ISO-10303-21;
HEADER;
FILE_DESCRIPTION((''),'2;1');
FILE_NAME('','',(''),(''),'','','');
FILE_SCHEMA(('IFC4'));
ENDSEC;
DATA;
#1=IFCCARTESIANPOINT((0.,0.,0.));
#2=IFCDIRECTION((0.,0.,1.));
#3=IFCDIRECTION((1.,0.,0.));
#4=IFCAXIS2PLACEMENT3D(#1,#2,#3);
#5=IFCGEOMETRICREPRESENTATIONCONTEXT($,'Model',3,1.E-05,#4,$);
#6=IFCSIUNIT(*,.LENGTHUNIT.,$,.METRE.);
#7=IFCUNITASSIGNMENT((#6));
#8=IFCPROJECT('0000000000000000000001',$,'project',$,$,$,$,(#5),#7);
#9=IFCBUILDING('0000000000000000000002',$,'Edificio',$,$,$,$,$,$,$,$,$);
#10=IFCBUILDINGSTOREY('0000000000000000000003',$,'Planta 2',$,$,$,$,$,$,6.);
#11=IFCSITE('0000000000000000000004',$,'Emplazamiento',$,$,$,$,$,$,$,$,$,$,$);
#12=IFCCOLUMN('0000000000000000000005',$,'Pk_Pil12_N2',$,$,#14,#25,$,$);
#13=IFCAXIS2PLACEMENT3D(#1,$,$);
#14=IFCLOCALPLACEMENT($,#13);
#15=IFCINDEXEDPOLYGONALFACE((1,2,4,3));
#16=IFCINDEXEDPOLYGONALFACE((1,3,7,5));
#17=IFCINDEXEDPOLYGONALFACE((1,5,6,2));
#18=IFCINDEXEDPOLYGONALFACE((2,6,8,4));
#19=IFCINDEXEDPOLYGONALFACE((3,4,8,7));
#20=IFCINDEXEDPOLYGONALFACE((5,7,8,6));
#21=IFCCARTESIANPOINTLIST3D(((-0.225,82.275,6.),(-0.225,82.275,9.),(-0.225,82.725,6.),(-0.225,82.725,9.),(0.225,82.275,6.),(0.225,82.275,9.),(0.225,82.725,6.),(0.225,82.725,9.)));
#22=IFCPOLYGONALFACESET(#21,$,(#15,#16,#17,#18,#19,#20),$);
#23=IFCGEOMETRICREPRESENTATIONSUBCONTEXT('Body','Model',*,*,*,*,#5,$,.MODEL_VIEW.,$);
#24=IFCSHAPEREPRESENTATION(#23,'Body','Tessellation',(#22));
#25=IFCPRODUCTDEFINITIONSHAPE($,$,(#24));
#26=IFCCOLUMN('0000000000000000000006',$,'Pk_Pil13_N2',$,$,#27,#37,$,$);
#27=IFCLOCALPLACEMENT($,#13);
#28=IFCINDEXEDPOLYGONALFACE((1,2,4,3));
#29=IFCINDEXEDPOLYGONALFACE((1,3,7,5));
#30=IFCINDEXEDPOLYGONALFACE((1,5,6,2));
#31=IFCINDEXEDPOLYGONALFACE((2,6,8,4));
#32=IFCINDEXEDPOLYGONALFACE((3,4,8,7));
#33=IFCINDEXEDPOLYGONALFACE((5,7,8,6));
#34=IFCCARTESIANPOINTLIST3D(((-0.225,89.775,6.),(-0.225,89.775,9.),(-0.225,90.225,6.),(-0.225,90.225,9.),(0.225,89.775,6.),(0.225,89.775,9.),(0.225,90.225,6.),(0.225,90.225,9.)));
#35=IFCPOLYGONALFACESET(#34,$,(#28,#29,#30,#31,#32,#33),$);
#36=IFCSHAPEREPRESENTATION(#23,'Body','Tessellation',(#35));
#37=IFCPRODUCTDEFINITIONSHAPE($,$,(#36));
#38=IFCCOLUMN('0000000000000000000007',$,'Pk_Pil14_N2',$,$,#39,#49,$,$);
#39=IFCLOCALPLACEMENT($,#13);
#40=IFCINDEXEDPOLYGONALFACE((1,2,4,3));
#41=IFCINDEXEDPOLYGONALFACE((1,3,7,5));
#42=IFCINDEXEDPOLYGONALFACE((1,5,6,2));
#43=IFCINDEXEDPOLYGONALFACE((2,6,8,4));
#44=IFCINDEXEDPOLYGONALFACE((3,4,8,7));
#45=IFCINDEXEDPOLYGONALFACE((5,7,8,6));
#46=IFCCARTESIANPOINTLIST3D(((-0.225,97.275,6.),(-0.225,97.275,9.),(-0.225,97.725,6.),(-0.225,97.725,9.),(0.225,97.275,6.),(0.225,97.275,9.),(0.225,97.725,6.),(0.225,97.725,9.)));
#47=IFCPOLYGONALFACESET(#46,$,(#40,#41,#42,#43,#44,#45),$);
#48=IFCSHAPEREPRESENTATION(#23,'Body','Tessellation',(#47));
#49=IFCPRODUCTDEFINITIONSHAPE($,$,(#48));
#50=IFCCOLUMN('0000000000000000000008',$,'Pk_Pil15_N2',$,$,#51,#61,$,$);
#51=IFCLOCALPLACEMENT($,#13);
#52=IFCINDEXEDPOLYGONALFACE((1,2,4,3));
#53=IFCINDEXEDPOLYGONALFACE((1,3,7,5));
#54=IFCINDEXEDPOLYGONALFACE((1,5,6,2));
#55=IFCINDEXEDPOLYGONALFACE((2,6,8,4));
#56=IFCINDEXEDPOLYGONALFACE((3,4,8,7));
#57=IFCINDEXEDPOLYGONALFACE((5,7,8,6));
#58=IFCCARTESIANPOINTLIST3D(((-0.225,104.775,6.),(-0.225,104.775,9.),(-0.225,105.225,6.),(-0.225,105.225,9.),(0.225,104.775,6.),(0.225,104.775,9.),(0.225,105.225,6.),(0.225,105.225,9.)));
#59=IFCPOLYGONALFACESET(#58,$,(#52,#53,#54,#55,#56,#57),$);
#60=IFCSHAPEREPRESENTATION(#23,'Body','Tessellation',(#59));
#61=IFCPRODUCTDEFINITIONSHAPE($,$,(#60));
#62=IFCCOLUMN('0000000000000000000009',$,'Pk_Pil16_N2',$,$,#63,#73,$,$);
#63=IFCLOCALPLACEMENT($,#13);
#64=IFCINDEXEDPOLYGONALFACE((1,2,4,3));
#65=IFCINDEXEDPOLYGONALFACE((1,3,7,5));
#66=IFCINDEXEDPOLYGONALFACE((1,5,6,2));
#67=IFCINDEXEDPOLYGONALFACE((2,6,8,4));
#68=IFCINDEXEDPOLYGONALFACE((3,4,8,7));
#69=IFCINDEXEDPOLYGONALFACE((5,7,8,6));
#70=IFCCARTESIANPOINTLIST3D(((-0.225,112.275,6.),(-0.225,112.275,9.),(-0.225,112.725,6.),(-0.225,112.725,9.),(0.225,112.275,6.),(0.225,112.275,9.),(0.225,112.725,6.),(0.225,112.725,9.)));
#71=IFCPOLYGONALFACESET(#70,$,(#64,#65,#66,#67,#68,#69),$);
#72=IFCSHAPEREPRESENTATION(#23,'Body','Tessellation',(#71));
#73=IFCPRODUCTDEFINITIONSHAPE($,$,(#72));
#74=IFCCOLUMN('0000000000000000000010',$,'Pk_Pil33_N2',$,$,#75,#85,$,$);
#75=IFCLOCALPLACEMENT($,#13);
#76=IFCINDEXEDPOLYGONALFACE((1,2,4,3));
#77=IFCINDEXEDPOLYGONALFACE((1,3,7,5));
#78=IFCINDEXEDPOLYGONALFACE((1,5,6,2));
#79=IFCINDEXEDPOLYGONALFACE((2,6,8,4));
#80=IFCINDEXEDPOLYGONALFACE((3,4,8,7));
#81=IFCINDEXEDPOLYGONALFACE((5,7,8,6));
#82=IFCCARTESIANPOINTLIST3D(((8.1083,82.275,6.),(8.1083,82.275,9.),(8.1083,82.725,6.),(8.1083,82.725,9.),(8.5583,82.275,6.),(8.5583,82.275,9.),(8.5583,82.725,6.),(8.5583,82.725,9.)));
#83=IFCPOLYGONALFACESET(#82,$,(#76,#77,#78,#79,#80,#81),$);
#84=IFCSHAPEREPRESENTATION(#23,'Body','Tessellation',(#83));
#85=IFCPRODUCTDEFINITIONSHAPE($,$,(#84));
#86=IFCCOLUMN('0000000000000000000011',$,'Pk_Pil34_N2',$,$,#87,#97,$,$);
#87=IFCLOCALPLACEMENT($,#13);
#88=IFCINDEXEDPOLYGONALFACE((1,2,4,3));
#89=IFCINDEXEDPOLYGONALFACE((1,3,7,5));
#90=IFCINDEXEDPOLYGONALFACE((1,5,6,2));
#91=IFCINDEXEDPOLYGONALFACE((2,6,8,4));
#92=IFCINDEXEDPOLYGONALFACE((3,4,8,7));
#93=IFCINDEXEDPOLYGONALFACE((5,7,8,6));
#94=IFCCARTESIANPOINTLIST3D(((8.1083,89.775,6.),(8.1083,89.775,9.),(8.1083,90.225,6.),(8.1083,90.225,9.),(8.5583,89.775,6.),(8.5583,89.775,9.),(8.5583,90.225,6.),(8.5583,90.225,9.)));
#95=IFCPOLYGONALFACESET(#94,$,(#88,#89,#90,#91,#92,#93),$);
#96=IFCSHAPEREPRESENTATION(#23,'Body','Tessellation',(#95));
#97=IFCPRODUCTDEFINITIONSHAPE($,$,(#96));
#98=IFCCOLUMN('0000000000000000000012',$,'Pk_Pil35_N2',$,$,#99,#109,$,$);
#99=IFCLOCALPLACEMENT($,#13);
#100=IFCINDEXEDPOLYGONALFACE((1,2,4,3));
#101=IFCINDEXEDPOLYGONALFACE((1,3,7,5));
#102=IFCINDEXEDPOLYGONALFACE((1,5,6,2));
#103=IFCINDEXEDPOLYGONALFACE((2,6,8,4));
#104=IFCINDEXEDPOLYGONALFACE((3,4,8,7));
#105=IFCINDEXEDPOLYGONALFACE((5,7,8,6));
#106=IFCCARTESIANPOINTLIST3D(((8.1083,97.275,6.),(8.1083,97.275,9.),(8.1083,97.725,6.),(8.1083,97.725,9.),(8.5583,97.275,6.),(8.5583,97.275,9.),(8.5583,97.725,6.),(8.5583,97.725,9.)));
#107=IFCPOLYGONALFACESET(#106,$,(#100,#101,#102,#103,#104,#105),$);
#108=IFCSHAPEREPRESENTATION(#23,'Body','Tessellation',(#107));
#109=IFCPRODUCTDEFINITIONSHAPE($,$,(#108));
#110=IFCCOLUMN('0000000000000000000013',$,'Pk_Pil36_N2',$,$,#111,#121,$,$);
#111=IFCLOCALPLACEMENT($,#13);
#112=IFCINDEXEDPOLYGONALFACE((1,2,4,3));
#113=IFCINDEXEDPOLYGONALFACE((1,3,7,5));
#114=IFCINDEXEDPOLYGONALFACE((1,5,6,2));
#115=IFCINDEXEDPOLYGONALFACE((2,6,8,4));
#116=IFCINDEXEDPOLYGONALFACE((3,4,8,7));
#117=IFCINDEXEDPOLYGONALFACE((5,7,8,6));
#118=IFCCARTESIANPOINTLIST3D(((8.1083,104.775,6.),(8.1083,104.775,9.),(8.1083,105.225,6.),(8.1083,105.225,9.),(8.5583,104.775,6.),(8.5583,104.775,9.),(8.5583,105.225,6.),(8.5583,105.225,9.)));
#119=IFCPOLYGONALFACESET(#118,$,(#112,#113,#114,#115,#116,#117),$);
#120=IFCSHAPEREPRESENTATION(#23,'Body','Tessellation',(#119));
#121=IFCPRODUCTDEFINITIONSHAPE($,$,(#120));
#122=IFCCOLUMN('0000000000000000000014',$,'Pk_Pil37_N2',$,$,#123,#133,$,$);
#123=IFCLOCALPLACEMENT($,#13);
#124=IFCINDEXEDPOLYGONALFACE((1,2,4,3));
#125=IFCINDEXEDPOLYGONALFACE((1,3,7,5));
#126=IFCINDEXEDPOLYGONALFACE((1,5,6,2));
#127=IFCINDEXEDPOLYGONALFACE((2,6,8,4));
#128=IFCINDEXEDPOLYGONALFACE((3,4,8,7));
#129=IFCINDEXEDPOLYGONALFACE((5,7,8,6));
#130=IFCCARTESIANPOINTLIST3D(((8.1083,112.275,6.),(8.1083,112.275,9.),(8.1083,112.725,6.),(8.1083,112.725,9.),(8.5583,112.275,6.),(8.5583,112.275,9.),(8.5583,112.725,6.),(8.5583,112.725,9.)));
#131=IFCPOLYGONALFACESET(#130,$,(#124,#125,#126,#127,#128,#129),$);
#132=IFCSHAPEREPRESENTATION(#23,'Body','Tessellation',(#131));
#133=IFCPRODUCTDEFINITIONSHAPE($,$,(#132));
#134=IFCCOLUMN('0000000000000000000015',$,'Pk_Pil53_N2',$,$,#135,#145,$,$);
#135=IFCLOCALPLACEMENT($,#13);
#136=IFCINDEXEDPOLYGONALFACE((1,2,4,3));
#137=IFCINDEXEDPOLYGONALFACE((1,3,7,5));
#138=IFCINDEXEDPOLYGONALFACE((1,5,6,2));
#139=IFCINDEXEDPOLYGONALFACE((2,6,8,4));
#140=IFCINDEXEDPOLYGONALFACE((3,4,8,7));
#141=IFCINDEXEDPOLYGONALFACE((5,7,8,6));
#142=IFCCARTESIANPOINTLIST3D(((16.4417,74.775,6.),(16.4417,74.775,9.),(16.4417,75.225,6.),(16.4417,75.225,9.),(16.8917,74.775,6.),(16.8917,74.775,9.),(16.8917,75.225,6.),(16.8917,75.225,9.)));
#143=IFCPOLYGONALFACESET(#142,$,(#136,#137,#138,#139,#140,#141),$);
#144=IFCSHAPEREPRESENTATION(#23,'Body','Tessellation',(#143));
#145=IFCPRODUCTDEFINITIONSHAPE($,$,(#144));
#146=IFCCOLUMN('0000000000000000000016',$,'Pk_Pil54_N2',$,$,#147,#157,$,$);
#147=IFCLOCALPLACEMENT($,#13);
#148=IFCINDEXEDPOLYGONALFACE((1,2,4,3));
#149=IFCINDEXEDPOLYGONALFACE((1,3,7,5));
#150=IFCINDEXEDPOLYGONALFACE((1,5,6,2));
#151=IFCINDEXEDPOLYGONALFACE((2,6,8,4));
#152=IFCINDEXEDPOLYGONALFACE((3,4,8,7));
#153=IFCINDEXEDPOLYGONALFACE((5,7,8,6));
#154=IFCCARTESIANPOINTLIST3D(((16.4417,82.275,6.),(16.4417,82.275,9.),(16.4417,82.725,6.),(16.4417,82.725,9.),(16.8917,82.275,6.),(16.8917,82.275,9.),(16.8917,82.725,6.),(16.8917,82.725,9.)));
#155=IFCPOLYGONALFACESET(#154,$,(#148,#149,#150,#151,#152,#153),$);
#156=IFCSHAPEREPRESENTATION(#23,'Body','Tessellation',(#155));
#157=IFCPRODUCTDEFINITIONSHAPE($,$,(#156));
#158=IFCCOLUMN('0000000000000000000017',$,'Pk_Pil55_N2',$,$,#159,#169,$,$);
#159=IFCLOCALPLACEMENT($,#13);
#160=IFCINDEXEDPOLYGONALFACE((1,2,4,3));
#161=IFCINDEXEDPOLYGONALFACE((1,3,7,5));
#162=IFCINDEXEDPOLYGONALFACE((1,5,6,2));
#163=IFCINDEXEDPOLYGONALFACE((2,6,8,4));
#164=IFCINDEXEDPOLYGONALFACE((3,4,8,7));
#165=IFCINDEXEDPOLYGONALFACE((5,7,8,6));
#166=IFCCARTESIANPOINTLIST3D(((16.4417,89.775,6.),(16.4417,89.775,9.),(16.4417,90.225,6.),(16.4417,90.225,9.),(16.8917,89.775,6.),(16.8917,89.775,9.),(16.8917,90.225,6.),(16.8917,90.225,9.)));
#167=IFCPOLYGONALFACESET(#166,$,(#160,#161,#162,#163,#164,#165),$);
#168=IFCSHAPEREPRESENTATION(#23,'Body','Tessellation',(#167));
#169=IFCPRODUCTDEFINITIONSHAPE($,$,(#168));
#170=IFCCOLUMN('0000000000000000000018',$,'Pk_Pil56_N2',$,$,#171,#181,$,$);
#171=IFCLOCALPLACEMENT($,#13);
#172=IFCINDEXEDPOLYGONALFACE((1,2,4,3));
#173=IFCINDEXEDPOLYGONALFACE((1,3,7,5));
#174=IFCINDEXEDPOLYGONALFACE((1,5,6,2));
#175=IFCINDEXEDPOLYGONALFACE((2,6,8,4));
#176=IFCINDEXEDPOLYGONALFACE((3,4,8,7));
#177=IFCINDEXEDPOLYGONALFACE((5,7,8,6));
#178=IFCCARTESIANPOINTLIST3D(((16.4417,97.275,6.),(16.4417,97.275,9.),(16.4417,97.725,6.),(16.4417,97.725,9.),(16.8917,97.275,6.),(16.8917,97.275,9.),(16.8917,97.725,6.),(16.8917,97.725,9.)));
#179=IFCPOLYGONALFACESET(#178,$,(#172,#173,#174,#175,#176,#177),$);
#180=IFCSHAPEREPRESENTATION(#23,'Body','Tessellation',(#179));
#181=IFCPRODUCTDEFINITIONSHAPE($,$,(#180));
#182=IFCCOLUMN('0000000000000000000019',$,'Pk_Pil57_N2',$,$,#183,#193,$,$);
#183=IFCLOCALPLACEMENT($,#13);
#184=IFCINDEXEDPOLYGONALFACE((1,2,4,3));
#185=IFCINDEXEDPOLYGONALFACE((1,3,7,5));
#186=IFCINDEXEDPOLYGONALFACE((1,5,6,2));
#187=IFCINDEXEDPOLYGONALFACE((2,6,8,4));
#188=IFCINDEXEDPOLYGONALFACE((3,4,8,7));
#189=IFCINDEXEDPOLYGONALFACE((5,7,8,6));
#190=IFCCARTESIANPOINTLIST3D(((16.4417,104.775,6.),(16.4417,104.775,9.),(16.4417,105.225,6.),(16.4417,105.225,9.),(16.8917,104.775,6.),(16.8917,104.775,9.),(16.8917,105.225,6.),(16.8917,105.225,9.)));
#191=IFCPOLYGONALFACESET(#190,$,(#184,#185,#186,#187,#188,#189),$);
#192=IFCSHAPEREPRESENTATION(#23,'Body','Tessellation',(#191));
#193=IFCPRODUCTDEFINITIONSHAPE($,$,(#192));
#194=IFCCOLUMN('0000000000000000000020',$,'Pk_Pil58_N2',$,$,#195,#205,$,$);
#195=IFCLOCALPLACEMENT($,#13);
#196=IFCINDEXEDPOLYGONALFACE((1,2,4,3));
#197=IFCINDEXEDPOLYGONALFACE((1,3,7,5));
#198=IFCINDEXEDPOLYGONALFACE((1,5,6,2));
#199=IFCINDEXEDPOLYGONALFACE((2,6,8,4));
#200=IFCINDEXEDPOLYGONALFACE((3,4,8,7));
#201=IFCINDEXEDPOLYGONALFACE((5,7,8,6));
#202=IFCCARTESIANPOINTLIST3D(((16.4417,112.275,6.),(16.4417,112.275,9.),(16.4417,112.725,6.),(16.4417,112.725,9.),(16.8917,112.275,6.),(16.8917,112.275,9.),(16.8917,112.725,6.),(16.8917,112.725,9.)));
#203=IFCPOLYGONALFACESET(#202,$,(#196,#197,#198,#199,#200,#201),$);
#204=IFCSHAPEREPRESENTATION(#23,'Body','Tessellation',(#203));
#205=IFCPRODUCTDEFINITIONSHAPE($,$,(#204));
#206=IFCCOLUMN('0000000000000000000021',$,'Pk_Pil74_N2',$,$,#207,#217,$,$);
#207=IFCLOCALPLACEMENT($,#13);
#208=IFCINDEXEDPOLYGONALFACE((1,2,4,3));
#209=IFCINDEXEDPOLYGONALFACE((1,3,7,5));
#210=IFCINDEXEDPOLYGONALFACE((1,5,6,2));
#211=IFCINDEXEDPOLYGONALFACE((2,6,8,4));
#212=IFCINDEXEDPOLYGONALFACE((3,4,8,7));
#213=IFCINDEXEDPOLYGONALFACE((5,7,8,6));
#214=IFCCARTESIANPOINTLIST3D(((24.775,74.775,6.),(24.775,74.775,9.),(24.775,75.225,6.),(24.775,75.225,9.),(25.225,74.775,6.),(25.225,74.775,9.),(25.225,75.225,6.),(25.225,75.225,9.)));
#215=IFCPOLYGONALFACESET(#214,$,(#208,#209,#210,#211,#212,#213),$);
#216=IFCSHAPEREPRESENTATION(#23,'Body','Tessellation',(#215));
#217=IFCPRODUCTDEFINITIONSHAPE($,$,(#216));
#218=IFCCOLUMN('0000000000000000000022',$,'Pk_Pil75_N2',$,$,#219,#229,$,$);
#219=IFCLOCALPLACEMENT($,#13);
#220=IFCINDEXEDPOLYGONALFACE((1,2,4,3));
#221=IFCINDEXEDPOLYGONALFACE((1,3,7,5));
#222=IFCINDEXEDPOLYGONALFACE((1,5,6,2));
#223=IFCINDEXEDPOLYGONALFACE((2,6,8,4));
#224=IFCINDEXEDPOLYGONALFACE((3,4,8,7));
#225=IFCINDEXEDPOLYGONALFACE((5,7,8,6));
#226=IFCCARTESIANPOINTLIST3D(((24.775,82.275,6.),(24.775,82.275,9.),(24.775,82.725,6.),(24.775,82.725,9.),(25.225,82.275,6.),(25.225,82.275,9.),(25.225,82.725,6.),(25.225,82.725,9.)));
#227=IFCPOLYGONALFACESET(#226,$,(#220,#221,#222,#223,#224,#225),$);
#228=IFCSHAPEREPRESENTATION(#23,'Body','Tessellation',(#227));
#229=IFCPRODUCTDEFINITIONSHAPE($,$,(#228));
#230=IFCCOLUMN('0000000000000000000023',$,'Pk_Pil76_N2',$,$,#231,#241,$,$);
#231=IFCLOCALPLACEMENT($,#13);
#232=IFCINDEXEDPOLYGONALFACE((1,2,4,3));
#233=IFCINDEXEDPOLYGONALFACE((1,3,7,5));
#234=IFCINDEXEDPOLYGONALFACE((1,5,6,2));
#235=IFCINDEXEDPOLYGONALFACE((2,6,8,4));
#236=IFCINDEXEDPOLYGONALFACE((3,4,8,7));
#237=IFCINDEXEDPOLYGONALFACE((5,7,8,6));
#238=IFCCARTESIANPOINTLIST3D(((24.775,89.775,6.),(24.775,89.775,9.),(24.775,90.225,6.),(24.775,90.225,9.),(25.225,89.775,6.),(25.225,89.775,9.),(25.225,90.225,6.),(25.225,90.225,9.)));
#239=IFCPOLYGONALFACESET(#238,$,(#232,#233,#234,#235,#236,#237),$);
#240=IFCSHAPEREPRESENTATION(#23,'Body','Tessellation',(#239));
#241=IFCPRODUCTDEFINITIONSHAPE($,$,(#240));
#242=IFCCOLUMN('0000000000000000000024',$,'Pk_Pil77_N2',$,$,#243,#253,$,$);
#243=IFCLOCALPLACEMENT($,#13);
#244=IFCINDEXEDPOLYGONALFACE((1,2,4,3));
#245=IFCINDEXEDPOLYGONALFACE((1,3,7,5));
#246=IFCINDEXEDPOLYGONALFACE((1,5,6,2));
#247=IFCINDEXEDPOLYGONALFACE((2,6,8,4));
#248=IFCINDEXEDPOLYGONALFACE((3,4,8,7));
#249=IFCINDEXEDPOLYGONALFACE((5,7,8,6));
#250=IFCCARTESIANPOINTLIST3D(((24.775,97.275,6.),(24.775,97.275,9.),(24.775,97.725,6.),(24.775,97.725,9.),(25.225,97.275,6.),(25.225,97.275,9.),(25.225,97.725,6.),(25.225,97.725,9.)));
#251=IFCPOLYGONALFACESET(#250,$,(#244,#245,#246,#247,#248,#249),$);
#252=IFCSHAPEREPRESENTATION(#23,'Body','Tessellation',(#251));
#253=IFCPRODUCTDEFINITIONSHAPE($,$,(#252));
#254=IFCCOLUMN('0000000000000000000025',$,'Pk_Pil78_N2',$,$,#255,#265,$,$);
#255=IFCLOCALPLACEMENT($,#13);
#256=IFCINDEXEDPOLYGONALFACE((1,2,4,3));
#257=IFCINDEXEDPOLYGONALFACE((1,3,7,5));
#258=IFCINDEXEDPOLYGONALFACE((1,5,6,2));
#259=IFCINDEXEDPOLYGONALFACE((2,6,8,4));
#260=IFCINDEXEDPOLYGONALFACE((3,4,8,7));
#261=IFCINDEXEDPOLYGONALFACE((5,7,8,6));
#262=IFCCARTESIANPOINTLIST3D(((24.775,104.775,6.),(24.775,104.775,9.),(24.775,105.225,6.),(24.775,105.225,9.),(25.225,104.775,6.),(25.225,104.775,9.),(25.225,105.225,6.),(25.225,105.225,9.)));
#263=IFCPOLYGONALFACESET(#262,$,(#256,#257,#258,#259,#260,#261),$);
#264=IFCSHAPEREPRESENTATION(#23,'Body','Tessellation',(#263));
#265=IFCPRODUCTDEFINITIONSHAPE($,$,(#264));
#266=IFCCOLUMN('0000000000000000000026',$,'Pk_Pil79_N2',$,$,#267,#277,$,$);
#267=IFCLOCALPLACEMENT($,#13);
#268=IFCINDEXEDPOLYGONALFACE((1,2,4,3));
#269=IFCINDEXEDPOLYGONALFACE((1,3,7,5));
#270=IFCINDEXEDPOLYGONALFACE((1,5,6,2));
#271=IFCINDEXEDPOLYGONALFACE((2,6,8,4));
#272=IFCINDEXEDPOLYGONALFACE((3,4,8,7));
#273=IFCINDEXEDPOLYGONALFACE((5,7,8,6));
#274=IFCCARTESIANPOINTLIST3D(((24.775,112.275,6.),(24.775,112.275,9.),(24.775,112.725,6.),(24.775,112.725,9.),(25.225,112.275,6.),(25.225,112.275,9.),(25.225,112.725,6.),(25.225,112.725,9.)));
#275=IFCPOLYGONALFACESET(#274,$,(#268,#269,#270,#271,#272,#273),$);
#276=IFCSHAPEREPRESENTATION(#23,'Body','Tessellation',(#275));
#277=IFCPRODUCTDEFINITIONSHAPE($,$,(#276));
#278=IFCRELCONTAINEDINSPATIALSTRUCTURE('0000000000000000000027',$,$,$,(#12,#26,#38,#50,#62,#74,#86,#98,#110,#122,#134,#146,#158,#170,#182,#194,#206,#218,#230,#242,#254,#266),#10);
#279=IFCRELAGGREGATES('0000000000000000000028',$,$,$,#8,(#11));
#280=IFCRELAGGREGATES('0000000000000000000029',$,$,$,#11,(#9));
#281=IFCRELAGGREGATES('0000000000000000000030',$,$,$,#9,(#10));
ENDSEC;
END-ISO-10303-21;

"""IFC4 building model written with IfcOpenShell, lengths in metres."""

from ifc_helpers import new_model, si_unit, frame, origin_with_axes, origin_2d, place, context, subcontext, project, spatial, rectangle, extrude, element, save


model = new_model("IFC4")

# Units and contexts
model_context = context("Model", 3, precision=1e-05, world=origin_with_axes())
body_context = subcontext(model_context, "Body", "Model", "MODEL_VIEW")
ifc_project = project(units=[si_unit("LENGTHUNIT", "METRE")], contexts=[model_context])

# Site, building, storey
site = spatial("IfcSite", under=ifc_project, Name="Emplazamiento")
building = spatial("IfcBuilding", under=site, Name="Edificio")
storey = spatial("IfcBuildingStorey", under=building, Name="Planta 2", Elevation=6.0)

# Columns
for number, where, z_axis, x_axis, name in (
    (1, (0.0, 82.5, 6.0), (0.0, 0.0, 1.0), (1.0, 0.0, 0.0), "Pk_Pil12_N2"),
    (2, (0.0, 90.0, 6.0), (0.0, 0.0, 1.0), (1.0, 0.0, 0.0), "Pk_Pil13_N2"),
    (3, (0.0, 97.5, 6.0), (0.0, 0.0, 1.0), (1.0, 0.0, 0.0), "Pk_Pil14_N2"),
    (4, (0.0, 105.0, 6.0), (0.0, 0.0, 1.0), (1.0, 0.0, 0.0), "Pk_Pil15_N2"),
    (5, (0.0, 112.5, 6.0), (0.0, 0.0, 1.0), (1.0, 0.0, 0.0), "Pk_Pil16_N2"),
    (6, (8.3333, 82.5, 6.0), (0.0, 0.0, 1.0), (1.0, 0.0, 0.0), "Pk_Pil33_N2"),
    (7, (8.3333, 90.0, 6.0), (0.0, 0.0, 1.0), (1.0, 0.0, 0.0), "Pk_Pil34_N2"),
    (8, (8.3333, 97.5, 6.0), (0.0, 0.0, 1.0), (1.0, 0.0, 0.0), "Pk_Pil35_N2"),
    (9, (8.3333, 105.0, 6.0), (0.0, 0.0, 1.0), (1.0, 0.0, 0.0), "Pk_Pil36_N2"),
    (10, (8.3333, 112.5, 6.0), (0.0, 0.0, 1.0), (1.0, 0.0, 0.0), "Pk_Pil37_N2"),
    (11, (16.6667, 75.0, 6.0), (0.0, 0.0, 1.0), (1.0, 0.0, 0.0), "Pk_Pil53_N2"),
    (12, (16.6667, 82.5, 6.0), (0.0, 0.0, 1.0), (1.0, 0.0, 0.0), "Pk_Pil54_N2"),
    (13, (16.6667, 90.0, 6.0), (0.0, 0.0, 1.0), (1.0, 0.0, 0.0), "Pk_Pil55_N2"),
    (14, (16.6667, 97.5, 6.0), (0.0, 0.0, 1.0), (1.0, 0.0, 0.0), "Pk_Pil56_N2"),
    (15, (16.6667, 105.0, 6.0), (0.0, 0.0, 1.0), (1.0, 0.0, 0.0), "Pk_Pil57_N2"),
    (16, (16.6667, 112.5, 6.0), (0.0, 0.0, 1.0), (1.0, 0.0, 0.0), "Pk_Pil58_N2"),
    (17, (25.0, 75.0, 6.0), (0.0, 0.0, 1.0), (1.0, 0.0, 0.0), "Pk_Pil74_N2"),
    (18, (25.0, 82.5, 6.0), (0.0, 0.0, 1.0), (1.0, 0.0, 0.0), "Pk_Pil75_N2"),
    (19, (25.0, 90.0, 6.0), (0.0, 0.0, 1.0), (1.0, 0.0, 0.0), "Pk_Pil76_N2"),
    (20, (25.0, 97.5, 6.0), (0.0, 0.0, 1.0), (1.0, 0.0, 0.0), "Pk_Pil77_N2"),
    (21, (25.0, 105.0, 6.0), (0.0, 0.0, 1.0), (1.0, 0.0, 0.0), "Pk_Pil78_N2"),
    (22, (25.0, 112.5, 6.0), (0.0, 0.0, 1.0), (1.0, 0.0, 0.0), "Pk_Pil79_N2"),
):
    element("IfcColumn", number, at=place(None, frame(where, z_axis=z_axis, x_axis=x_axis)), inside=storey, Name=name, context=body_context, shape_type="SweptSolid", body=[
        extrude(rectangle(XDim=0.45, YDim=0.45, at=origin_2d()), origin_with_axes(), (0.0, 0.0, 1.0), 3.0),
    ])

save(model, "model.ifc")
